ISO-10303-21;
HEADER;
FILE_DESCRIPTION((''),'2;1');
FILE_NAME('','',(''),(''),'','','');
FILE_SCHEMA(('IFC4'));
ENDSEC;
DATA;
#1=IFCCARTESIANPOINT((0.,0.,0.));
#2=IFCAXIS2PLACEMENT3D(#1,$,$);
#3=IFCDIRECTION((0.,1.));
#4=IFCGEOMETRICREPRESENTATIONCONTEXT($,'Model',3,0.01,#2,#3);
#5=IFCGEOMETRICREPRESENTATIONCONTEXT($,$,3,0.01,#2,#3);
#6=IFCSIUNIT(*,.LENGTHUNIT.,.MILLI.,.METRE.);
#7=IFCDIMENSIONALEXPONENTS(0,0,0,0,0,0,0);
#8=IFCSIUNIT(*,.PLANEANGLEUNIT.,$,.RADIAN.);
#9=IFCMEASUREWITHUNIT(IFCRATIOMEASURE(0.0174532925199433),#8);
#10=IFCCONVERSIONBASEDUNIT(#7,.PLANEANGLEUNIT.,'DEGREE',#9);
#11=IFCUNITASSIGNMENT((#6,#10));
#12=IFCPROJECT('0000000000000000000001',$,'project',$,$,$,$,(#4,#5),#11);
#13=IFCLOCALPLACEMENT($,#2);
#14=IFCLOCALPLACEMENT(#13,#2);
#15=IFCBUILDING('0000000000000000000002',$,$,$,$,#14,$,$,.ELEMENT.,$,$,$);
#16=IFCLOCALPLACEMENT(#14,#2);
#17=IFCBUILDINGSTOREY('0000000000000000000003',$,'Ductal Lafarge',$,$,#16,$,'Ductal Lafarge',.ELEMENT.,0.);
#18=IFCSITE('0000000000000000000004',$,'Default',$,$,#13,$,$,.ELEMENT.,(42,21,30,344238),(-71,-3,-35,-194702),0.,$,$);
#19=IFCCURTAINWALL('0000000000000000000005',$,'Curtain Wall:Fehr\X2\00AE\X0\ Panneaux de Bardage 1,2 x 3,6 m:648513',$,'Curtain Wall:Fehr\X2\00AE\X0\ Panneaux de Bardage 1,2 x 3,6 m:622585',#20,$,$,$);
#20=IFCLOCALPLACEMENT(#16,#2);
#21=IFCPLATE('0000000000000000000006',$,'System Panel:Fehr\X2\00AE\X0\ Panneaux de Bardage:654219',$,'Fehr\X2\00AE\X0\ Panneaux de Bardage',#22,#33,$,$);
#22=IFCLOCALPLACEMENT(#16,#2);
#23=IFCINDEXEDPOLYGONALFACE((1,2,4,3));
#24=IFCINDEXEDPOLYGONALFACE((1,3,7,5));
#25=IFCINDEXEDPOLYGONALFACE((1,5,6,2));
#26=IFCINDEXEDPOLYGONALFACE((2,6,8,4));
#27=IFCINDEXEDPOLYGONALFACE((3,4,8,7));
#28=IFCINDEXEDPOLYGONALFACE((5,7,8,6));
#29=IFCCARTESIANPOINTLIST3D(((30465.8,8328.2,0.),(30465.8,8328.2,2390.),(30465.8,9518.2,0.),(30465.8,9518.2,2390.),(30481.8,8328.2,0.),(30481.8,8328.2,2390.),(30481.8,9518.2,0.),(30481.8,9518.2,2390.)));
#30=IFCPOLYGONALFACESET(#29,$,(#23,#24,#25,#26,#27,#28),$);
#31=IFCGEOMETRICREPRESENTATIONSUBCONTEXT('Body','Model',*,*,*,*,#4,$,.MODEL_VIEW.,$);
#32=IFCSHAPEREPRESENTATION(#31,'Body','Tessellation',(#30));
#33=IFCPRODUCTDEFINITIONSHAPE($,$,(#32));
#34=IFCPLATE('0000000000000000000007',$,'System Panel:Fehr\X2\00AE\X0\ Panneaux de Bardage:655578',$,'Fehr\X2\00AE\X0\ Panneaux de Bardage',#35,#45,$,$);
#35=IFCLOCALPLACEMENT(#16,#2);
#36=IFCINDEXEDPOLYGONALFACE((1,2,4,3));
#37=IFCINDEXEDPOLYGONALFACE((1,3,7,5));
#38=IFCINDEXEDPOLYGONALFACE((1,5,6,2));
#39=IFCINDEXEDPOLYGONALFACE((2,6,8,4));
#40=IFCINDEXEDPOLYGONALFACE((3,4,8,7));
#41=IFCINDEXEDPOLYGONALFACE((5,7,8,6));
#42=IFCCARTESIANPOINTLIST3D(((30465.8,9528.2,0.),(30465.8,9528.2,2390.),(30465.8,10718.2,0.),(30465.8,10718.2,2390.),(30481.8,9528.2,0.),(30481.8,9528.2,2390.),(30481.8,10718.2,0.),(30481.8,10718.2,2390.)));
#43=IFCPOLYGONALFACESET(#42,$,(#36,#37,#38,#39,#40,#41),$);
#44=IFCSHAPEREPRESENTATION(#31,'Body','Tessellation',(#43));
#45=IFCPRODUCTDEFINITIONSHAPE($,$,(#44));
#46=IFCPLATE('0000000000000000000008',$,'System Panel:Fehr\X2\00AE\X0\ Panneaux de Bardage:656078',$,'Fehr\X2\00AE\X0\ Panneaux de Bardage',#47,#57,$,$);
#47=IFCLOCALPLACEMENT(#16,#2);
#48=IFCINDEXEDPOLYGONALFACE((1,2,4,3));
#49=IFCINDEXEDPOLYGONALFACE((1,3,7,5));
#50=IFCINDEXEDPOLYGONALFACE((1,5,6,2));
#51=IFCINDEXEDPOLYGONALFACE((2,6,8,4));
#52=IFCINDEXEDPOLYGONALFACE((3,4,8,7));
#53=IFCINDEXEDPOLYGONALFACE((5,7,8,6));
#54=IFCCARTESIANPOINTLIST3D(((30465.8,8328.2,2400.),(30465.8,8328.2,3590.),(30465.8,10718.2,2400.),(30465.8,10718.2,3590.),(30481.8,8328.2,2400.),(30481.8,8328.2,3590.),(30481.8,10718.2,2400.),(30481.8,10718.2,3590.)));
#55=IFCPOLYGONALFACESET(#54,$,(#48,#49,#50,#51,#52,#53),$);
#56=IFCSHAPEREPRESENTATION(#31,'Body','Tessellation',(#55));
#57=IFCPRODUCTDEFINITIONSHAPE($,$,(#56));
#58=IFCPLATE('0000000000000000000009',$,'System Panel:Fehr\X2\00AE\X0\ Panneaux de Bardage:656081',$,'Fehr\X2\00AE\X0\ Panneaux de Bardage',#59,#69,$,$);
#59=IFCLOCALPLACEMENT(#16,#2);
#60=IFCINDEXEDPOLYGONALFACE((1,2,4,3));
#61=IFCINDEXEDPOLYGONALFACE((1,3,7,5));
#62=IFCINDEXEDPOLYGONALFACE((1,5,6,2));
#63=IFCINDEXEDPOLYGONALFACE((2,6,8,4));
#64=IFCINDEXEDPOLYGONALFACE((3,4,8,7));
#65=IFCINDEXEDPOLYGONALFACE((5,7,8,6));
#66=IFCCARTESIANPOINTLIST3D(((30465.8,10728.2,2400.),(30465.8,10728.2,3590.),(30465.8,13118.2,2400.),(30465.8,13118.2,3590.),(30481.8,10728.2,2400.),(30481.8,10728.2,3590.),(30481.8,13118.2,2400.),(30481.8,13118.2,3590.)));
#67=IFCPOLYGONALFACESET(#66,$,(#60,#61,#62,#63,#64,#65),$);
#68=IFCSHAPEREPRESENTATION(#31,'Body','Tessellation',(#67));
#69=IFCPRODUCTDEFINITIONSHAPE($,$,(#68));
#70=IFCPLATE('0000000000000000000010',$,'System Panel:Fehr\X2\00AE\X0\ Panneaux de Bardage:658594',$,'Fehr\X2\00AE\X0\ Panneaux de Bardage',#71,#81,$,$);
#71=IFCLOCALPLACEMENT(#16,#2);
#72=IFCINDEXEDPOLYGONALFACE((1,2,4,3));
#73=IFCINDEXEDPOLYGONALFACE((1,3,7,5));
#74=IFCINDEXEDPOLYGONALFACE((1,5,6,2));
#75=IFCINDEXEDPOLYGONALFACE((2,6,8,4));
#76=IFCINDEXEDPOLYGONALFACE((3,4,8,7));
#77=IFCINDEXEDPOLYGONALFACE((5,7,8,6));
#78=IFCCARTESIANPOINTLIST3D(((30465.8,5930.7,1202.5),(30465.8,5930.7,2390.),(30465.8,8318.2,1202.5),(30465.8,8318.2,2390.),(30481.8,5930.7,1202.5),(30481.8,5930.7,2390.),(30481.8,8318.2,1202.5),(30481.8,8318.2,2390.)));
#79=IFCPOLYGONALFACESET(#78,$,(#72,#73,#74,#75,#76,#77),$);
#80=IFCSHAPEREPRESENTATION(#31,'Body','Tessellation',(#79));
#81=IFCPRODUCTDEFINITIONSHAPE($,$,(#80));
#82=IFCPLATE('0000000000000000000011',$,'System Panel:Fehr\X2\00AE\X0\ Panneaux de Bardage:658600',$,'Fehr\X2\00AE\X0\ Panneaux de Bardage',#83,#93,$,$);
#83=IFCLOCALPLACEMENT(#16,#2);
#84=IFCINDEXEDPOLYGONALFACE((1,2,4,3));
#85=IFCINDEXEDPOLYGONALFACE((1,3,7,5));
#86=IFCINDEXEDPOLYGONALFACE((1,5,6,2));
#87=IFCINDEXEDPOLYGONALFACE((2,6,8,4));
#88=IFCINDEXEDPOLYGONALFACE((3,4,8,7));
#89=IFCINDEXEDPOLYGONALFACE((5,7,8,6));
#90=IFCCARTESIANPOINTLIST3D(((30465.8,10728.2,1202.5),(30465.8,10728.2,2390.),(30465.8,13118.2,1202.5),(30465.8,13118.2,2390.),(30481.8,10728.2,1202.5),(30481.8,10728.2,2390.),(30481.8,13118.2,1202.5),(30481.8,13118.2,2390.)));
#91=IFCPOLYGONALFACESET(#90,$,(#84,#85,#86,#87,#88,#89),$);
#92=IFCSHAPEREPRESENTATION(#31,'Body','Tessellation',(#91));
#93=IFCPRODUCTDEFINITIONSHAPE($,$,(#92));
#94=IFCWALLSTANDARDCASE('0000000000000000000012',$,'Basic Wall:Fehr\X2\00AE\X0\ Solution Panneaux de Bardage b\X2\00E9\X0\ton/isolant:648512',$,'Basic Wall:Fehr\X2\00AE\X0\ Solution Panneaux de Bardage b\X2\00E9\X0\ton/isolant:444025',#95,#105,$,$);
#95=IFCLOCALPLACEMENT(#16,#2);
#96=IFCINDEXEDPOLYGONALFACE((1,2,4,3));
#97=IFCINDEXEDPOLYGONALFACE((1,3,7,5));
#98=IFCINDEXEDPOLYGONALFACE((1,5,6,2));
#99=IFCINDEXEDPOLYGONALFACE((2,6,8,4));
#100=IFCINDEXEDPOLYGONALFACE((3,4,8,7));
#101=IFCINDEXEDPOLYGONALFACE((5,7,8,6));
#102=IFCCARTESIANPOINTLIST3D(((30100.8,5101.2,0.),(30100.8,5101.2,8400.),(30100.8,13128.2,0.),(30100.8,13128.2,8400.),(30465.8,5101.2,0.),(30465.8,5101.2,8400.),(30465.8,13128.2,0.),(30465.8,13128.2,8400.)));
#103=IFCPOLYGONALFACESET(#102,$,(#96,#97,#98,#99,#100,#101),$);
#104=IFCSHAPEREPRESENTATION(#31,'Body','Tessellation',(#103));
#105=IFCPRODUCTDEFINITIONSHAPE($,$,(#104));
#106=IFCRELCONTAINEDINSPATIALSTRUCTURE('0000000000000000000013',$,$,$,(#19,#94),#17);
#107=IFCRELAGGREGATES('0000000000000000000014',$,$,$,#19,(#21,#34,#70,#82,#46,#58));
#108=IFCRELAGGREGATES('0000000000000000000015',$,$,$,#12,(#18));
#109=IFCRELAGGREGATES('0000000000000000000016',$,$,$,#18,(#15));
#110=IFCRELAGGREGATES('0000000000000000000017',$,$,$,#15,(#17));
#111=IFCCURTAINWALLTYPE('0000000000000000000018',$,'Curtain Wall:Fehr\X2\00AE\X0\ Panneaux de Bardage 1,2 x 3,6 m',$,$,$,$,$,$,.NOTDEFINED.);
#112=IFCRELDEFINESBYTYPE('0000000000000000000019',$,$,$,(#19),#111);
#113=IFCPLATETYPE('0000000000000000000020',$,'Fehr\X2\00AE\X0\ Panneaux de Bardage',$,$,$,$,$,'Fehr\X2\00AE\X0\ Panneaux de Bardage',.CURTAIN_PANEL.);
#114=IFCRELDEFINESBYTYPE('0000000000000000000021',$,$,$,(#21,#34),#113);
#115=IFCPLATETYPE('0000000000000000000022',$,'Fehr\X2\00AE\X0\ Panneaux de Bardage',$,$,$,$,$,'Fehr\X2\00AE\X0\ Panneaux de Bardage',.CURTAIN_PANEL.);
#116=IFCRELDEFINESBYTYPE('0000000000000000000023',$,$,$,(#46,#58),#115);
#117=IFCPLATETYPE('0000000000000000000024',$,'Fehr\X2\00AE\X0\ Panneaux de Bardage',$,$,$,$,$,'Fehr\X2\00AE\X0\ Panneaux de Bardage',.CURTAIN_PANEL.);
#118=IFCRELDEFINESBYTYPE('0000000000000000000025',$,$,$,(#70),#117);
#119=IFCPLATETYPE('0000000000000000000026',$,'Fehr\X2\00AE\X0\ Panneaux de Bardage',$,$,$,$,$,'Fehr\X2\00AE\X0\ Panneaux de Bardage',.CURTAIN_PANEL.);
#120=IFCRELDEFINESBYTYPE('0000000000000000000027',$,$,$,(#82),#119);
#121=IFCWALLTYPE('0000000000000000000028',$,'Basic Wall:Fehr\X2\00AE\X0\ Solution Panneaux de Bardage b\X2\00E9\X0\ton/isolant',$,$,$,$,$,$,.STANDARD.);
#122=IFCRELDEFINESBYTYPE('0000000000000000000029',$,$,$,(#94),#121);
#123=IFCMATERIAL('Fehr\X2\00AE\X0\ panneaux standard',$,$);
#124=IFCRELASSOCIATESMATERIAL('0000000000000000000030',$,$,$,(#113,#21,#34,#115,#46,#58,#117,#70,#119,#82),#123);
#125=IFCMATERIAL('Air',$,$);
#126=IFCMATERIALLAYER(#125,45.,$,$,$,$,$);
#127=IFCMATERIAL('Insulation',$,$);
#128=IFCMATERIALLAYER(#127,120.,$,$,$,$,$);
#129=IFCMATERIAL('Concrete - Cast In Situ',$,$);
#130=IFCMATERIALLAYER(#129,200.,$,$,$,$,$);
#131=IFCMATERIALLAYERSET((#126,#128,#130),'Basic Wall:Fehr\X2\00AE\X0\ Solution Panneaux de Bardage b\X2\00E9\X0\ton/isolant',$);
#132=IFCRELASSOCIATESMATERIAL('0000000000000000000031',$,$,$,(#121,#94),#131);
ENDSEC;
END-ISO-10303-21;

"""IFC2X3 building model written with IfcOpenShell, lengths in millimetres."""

from ifc_helpers import new_model, entity, si_unit, converted_unit, direction, frame, frame_2d, origin, origin_2d_with_axis, place, context, subcontext, project, spatial, rectangle, extrude, source, transform, mapped, material, layer, layer_set, layer_usage, type_object, type_shapes, element, aggregate, save


model = new_model("IFC2X3")

# Units and contexts
model_context = context("Model", 3, precision=0.01, world=origin(), true_north=direction((0.0, 1.0)))
context_of_model = context(None, 3, precision=0.01, world=origin(), true_north=direction((0.0, 1.0)))
body_context = subcontext(model_context, "Body", "Model", "MODEL_VIEW")
ifc_project = project(units=[si_unit("LENGTHUNIT", "METRE", prefix="MILLI"), converted_unit("PLANEANGLEUNIT", "DEGREE", entity("IfcRatioMeasure", 0.0174532925199433), si_unit("PLANEANGLEUNIT", "RADIAN"), dimensions=[0, 0, 0, 0, 0, 0, 0])], contexts=[model_context, context_of_model])

# Site, building, storey
site_placement = place(None, origin())
site = spatial("IfcSite", under=ifc_project, at=site_placement, Name="Default", CompositionType="ELEMENT", RefLatitude=(42, 21, 30, 344238), RefLongitude=(-71, -3, -35, -194702), RefElevation=0.0)
building_placement = place(site_placement, origin())
building = spatial("IfcBuilding", under=site, at=building_placement, CompositionType="ELEMENT")
storey_placement = place(building_placement, origin())
storey = spatial("IfcBuildingStorey", under=building, at=storey_placement, Name="Ductal Lafarge", LongName="Ductal Lafarge", CompositionType="ELEMENT", Elevation=0.0)

# Curtain wall, plates
curtain_wall_type = type_object("IfcCurtainWallType", Name="Curtain Wall:Fehr® Panneaux de Bardage 1,2 x 3,6 m", PredefinedType="NOTDEFINED")
curtain_wall_placement = place(storey_placement, origin())
curtain_wall = element("IfcCurtainWall", 1, at=curtain_wall_placement, inside=storey, type_object=curtain_wall_type, Name="Curtain Wall:Fehr® Panneaux de Bardage 1,2 x 3,6 m:648513", ObjectType="Curtain Wall:Fehr® Panneaux de Bardage 1,2 x 3,6 m:622585")
ifc_material_1 = material(Name="Fehr® panneaux standard")
plate_type_1 = type_object("IfcPlateType", Name="Fehr® Panneaux de Bardage", ElementType="Fehr® Panneaux de Bardage", PredefinedType="CURTAIN_PANEL", material=ifc_material_1)
shared_shape_1 = source(origin(), body_context, "Body", "SweptSolid", [
    extrude(rectangle(XDim=2390.0, YDim=1190.0, at=frame_2d((-0.8, 0.0), x_axis=(1.0, 0.0))), frame((0.0, -8.0, 1195.8), z_axis=(0.0, 1.0, 0.0), x_axis=(0.0, 0.0, 1.0)), (0.0, 0.0, 1.0), 16.0),
])
type_shapes(plate_type_1, [shared_shape_1])
plate_1_placement = place(curtain_wall_placement, frame((30473.8, 8923.2, 0.0), z_axis=(0.0, 0.0, 1.0), x_axis=(0.0, 1.0, 0.0)))
plate_1 = element("IfcPlate", 2, at=plate_1_placement, type_object=plate_type_1, material=ifc_material_1, Name="System Panel:Fehr® Panneaux de Bardage:654219", ObjectType="Fehr® Panneaux de Bardage", context=body_context, shape_type="MappedRepresentation", body=[
    mapped(shared_shape_1, transform((0.0, 0.0, 0.0), scale=1.0)),
])
plate_2_placement = place(curtain_wall_placement, frame((30473.8, 10123.2, 0.0), z_axis=(0.0, 0.0, 1.0), x_axis=(0.0, 1.0, 0.0)))
plate_2 = element("IfcPlate", 3, at=plate_2_placement, type_object=plate_type_1, material=ifc_material_1, Name="System Panel:Fehr® Panneaux de Bardage:655578", ObjectType="Fehr® Panneaux de Bardage", context=body_context, shape_type="MappedRepresentation", body=[
    mapped(shared_shape_1, transform((0.0, 0.0, 0.0), scale=1.0)),
])
plate_type_2 = type_object("IfcPlateType", Name="Fehr® Panneaux de Bardage", ElementType="Fehr® Panneaux de Bardage", PredefinedType="CURTAIN_PANEL", material=ifc_material_1)
shared_shape_2 = source(origin(), body_context, "Body", "SweptSolid", [
    extrude(rectangle(XDim=1190.0, YDim=2390.0, at=origin_2d_with_axis()), frame((0.0, -8.0, 595.0), z_axis=(0.0, 1.0, 0.0), x_axis=(0.0, 0.0, 1.0)), (0.0, 0.0, 1.0), 16.0),
])
type_shapes(plate_type_2, [shared_shape_2])
plate_3_placement = place(curtain_wall_placement, frame((30473.8, 9523.2, 2400.0), z_axis=(0.0, 0.0, 1.0), x_axis=(0.0, 1.0, 0.0)))
plate_3 = element("IfcPlate", 4, at=plate_3_placement, type_object=plate_type_2, material=ifc_material_1, Name="System Panel:Fehr® Panneaux de Bardage:656078", ObjectType="Fehr® Panneaux de Bardage", context=body_context, shape_type="MappedRepresentation", body=[
    mapped(shared_shape_2, transform((0.0, 0.0, 0.0), scale=1.0)),
])
plate_4_placement = place(curtain_wall_placement, frame((30473.8, 11923.2, 2400.0), z_axis=(0.0, 0.0, 1.0), x_axis=(0.0, 1.0, 0.0)))
plate_4 = element("IfcPlate", 5, at=plate_4_placement, type_object=plate_type_2, material=ifc_material_1, Name="System Panel:Fehr® Panneaux de Bardage:656081", ObjectType="Fehr® Panneaux de Bardage", context=body_context, shape_type="MappedRepresentation", body=[
    mapped(shared_shape_2, transform((0.0, 0.0, 0.0), scale=1.0)),
])
plate_type_3 = type_object("IfcPlateType", Name="Fehr® Panneaux de Bardage", ElementType="Fehr® Panneaux de Bardage", PredefinedType="CURTAIN_PANEL", material=ifc_material_1)
shared_shape_3 = source(origin(), body_context, "Body", "SweptSolid", [
    extrude(rectangle(XDim=1187.5, YDim=2387.5, at=frame_2d((0.0, 0.4), x_axis=(1.0, 0.0))), frame((-0.4, -8.0, 593.8), z_axis=(0.0, 1.0, 0.0), x_axis=(0.0, 0.0, 1.0)), (0.0, 0.0, 1.0), 16.0),
])
type_shapes(plate_type_3, [shared_shape_3])
plate_5_placement = place(curtain_wall_placement, frame((30473.8, 7124.4, 1202.5), z_axis=(0.0, 0.0, 1.0), x_axis=(0.0, 1.0, 0.0)))
plate_5 = element("IfcPlate", 6, at=plate_5_placement, type_object=plate_type_3, material=ifc_material_1, Name="System Panel:Fehr® Panneaux de Bardage:658594", ObjectType="Fehr® Panneaux de Bardage", context=body_context, shape_type="MappedRepresentation", body=[
    mapped(shared_shape_3, transform((0.0, 0.0, 0.0), scale=1.0)),
])
plate_type_4 = type_object("IfcPlateType", Name="Fehr® Panneaux de Bardage", ElementType="Fehr® Panneaux de Bardage", PredefinedType="CURTAIN_PANEL", material=ifc_material_1)
shared_shape_4 = source(origin(), body_context, "Body", "SweptSolid", [
    extrude(rectangle(XDim=1187.5, YDim=2390.0, at=frame_2d((0.0, 0.0), x_axis=(1.0, 0.0))), frame((0.0, -8.0, 593.8), z_axis=(0.0, 1.0, 0.0), x_axis=(0.0, 0.0, 1.0)), (0.0, 0.0, 1.0), 16.0),
])
type_shapes(plate_type_4, [shared_shape_4])
plate_6_placement = place(curtain_wall_placement, frame((30473.8, 11923.2, 1202.5), z_axis=(0.0, 0.0, 1.0), x_axis=(0.0, 1.0, 0.0)))
plate_6 = element("IfcPlate", 7, at=plate_6_placement, type_object=plate_type_4, material=ifc_material_1, Name="System Panel:Fehr® Panneaux de Bardage:658600", ObjectType="Fehr® Panneaux de Bardage", context=body_context, shape_type="MappedRepresentation", body=[
    mapped(shared_shape_4, transform((0.0, 0.0, 0.0), scale=1.0)),
])
aggregate(curtain_wall, [plate_1, plate_2, plate_5, plate_6, plate_3, plate_4])

# Wall
ifc_material_2 = material(Name="Air")
ifc_layer_1 = layer(ifc_material_2, 45.0)
ifc_material_3 = material(Name="Insulation")
ifc_layer_2 = layer(ifc_material_3, 120.0)
ifc_material_4 = material(Name="Concrete - Cast In Situ")
ifc_layer_3 = layer(ifc_material_4, 200.0)
ifc_layer_set = layer_set([ifc_layer_1, ifc_layer_2, ifc_layer_3], Name="Basic Wall:Fehr® Solution Panneaux de Bardage béton/isolant")
ifc_layer_usage = layer_usage(ifc_layer_set, "AXIS2", "NEGATIVE", 182.5)
wall_type = type_object("IfcWallType", Name="Basic Wall:Fehr® Solution Panneaux de Bardage béton/isolant", PredefinedType="STANDARD", material=ifc_layer_set)
wall_placement = place(storey_placement, frame((30283.3, 13128.2, 0.0), z_axis=(0.0, 0.0, 1.0), x_axis=(0.0, -1.0, 0.0)))
element("IfcWallStandardCase", 8, at=wall_placement, inside=storey, type_object=wall_type, material=ifc_layer_usage, Name="Basic Wall:Fehr® Solution Panneaux de Bardage béton/isolant:648512", ObjectType="Basic Wall:Fehr® Solution Panneaux de Bardage béton/isolant:444025", context=body_context, shape_type="SweptSolid", body=[
    extrude(rectangle(XDim=8027.0, YDim=365.0, at=frame_2d((4013.5, 0.0), x_axis=(-1.0, 0.0))), origin(), (0.0, 0.0, 1.0), 8400.0),
])

save(model, "model.ifc")
